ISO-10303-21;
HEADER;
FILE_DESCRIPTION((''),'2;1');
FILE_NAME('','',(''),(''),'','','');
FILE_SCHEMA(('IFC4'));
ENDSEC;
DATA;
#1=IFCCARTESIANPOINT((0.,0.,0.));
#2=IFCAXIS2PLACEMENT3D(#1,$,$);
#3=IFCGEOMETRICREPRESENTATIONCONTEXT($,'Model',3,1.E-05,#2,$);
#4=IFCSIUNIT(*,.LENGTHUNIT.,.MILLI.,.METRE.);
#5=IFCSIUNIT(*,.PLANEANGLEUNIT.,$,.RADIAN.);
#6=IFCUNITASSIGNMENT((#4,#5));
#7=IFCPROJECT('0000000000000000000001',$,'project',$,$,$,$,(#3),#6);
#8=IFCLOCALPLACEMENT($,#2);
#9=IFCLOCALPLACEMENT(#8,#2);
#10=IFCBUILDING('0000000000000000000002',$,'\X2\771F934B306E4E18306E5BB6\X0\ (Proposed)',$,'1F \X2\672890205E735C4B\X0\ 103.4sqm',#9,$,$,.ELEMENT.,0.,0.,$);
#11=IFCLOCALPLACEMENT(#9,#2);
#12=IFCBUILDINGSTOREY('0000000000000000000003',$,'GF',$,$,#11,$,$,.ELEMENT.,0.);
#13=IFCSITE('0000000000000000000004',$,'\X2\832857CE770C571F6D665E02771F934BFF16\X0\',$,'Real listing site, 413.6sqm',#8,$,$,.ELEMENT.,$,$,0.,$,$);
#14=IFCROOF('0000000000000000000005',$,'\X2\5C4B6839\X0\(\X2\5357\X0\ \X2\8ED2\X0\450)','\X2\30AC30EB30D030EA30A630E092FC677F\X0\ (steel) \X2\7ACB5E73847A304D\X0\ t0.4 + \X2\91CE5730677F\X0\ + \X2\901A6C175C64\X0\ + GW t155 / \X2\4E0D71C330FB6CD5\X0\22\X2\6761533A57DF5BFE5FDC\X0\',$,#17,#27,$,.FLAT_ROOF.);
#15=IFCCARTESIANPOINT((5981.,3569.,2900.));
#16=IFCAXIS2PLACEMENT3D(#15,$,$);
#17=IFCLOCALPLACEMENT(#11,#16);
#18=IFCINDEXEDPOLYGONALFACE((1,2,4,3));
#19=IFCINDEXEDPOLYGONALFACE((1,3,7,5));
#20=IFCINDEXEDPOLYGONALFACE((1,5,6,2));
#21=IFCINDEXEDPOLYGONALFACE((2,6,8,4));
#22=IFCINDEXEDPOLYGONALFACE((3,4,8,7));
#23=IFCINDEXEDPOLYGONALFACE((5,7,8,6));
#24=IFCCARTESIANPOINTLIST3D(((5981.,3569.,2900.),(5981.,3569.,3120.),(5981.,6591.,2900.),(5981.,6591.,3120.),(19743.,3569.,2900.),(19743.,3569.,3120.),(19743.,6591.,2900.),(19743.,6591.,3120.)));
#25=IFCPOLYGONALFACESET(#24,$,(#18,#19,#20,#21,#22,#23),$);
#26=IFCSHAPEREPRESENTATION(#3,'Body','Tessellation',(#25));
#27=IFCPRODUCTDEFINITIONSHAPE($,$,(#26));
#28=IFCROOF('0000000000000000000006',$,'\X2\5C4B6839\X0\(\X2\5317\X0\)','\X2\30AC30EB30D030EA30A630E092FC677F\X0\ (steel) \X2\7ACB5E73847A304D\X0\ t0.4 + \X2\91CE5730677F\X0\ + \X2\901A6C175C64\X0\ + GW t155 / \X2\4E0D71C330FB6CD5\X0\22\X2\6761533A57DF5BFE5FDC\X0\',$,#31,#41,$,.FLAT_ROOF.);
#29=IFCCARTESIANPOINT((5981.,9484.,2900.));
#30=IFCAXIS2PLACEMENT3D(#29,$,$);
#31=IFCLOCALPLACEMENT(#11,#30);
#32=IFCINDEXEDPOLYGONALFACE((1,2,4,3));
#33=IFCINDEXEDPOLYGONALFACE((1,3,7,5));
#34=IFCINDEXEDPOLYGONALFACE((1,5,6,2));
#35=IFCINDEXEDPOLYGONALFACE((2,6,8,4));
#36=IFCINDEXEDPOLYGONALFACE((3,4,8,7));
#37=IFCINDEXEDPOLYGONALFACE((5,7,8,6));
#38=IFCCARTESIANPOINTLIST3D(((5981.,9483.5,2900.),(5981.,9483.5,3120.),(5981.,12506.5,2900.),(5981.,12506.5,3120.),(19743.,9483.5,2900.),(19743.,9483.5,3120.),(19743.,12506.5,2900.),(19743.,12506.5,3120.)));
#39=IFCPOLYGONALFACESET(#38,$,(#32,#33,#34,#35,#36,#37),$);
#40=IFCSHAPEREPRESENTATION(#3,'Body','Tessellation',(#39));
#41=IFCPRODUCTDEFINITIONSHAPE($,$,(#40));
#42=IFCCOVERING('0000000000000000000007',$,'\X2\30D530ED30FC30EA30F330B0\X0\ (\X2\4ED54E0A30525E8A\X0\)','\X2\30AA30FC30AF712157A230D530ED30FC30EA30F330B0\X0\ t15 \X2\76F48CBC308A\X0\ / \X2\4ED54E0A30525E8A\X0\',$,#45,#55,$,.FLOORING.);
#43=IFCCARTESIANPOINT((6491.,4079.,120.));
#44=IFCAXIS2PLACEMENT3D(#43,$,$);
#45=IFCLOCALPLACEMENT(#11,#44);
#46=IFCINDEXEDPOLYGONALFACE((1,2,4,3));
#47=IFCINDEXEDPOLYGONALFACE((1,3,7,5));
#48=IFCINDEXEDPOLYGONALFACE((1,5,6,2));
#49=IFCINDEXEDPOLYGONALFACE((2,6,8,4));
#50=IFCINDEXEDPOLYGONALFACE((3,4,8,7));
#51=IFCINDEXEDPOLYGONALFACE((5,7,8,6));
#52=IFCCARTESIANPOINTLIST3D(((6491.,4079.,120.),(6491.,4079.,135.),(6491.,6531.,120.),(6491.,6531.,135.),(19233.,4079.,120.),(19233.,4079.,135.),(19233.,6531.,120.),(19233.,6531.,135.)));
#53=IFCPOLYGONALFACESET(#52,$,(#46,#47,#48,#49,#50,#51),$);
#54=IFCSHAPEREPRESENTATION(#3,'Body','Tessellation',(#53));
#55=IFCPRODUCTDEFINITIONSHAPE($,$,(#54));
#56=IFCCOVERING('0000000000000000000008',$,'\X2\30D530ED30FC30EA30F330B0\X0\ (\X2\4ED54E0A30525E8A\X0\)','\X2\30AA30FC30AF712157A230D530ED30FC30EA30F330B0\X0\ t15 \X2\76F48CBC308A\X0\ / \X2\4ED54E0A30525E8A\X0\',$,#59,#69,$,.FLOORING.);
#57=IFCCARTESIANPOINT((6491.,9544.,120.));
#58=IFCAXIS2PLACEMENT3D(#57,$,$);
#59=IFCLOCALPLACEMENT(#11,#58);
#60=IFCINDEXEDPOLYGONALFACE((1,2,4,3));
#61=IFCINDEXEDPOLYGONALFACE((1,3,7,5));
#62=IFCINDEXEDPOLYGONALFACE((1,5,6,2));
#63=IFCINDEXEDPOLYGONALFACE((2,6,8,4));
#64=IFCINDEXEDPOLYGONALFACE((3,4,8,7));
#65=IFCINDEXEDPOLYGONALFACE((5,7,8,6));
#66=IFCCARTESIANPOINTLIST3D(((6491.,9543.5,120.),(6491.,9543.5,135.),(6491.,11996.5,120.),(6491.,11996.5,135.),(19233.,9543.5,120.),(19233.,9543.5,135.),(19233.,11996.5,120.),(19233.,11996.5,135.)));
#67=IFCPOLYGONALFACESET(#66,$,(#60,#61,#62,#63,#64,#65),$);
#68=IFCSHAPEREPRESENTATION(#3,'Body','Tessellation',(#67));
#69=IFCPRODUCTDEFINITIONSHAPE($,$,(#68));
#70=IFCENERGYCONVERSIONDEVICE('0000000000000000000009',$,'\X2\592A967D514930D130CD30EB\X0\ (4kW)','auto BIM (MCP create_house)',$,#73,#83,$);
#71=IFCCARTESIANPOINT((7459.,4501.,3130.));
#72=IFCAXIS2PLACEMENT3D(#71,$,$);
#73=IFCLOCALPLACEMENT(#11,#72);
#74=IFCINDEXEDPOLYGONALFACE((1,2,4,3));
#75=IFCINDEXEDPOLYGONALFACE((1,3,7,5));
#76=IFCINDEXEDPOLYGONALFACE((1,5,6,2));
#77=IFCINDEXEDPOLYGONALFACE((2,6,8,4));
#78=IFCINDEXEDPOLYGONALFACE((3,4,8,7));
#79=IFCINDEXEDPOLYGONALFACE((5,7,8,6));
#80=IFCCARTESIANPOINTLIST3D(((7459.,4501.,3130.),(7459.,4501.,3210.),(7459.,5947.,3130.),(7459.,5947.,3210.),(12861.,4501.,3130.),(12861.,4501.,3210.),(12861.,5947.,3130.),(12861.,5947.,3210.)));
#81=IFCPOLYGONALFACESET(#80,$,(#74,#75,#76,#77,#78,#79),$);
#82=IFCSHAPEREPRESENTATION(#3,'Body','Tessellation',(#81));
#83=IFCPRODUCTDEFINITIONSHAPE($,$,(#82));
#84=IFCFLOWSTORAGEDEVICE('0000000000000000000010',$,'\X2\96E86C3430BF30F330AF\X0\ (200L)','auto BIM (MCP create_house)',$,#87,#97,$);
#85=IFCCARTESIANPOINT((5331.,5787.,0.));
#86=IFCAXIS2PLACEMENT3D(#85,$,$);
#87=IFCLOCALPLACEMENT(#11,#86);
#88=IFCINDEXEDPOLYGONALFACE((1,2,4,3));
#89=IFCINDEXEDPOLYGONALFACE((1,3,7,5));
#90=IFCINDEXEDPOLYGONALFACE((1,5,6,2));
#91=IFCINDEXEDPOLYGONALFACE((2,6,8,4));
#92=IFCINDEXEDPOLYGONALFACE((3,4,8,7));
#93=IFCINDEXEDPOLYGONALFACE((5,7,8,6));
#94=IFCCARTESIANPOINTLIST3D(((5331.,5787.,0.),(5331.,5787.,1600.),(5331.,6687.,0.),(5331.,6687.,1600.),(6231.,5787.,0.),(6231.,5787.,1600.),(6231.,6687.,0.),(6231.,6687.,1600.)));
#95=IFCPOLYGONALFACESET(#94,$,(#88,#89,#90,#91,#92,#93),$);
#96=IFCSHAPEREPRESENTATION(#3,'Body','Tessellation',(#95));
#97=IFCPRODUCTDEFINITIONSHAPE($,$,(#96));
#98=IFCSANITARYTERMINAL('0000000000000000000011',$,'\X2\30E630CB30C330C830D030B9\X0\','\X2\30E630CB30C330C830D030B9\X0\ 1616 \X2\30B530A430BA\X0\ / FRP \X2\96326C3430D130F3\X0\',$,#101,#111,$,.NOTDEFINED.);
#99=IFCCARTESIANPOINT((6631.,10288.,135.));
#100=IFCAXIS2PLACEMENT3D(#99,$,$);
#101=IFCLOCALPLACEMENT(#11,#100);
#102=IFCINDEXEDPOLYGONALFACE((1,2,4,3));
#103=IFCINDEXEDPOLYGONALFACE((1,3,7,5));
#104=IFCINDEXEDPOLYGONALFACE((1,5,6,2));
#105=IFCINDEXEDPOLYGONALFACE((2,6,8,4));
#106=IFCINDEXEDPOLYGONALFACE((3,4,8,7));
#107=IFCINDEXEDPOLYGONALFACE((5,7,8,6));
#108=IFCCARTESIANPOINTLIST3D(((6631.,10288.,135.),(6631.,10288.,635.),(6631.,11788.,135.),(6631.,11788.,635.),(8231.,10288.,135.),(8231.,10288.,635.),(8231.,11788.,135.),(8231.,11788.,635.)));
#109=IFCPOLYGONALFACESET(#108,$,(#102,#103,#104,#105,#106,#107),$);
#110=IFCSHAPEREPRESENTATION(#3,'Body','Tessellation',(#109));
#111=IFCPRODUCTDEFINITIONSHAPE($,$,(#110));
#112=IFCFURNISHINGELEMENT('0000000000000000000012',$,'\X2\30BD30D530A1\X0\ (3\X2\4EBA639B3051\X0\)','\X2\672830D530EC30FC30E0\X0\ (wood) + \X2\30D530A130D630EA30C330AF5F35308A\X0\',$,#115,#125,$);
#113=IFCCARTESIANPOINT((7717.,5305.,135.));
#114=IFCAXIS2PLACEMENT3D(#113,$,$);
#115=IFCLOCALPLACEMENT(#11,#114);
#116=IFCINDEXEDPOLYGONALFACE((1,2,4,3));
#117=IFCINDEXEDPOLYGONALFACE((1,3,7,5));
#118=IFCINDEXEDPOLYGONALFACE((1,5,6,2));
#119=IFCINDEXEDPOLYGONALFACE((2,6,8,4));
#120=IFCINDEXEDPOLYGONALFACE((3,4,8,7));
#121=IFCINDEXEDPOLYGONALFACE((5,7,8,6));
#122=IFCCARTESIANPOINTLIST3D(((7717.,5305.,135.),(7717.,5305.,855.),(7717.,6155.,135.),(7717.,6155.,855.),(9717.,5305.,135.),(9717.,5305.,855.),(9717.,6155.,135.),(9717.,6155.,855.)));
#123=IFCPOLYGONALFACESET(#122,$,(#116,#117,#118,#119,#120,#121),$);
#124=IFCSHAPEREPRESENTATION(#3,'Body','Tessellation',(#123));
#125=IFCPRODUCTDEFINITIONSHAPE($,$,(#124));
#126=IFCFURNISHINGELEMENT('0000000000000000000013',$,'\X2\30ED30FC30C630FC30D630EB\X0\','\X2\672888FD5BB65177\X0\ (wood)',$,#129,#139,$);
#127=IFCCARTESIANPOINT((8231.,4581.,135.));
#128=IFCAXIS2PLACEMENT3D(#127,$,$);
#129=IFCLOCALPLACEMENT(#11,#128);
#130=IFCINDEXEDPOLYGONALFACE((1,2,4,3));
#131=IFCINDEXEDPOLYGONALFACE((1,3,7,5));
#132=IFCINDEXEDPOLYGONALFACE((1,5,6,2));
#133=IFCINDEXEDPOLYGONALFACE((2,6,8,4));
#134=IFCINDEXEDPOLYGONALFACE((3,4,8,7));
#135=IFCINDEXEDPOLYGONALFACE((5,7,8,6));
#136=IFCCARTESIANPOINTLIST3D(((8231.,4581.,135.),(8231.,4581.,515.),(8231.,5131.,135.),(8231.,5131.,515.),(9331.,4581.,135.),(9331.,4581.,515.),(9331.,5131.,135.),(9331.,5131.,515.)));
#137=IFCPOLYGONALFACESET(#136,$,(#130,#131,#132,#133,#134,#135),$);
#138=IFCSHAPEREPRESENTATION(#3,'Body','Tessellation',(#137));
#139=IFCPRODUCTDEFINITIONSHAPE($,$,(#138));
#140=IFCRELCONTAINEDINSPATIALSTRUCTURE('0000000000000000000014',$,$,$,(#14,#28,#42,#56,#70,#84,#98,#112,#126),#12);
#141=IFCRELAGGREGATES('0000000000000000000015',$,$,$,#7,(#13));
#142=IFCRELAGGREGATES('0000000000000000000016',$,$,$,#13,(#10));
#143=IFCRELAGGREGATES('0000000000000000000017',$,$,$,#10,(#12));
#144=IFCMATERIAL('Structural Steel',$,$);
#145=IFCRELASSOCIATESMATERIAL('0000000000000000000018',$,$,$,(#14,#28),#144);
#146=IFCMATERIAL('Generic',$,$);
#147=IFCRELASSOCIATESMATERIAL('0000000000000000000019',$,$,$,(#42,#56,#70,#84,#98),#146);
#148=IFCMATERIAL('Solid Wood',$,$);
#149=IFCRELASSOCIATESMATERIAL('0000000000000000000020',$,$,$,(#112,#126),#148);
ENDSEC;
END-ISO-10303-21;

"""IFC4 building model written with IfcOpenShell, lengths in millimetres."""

from ifc_helpers import new_model, si_unit, frame, frame_2d, origin, place, context, project, spatial, rectangle, extrude, material, element, save


model = new_model("IFC4")

# Units and contexts
model_context = context("Model", 3, precision=1e-05, world=origin())
ifc_project = project(units=[si_unit("LENGTHUNIT", "METRE", prefix="MILLI"), si_unit("PLANEANGLEUNIT", "RADIAN")], contexts=[model_context])

# Site, building, storey
site_placement = place(None, origin())
site = spatial("IfcSite", under=ifc_project, at=site_placement, Name="茨城県土浦市真鍋６", ObjectType="Real listing site, 413.6sqm", CompositionType="ELEMENT", RefElevation=0.0)
building_placement = place(site_placement, origin())
building = spatial("IfcBuilding", under=site, at=building_placement, Name="真鍋の丘の家 (Proposed)", ObjectType="1F 木造平屋 103.4sqm", CompositionType="ELEMENT", ElevationOfRefHeight=0.0, ElevationOfTerrain=0.0)
storey_placement = place(building_placement, origin())
storey = spatial("IfcBuildingStorey", under=building, at=storey_placement, Name="GF", CompositionType="ELEMENT", Elevation=0.0)

# Shared definitions
ifc_material_1 = material(Name="Solid Wood")

# Roofs
ifc_material_2 = material(Name="Structural Steel")
roof_1_placement = place(storey_placement, frame((5981.0, 3569.0, 2900.0)))
element("IfcRoof", 1, at=roof_1_placement, inside=storey, material=ifc_material_2, Name="屋根(南 軒450)", Description="ガルバリウム鋼板 (steel) 立平葺き t0.4 + 野地板 + 通気層 + GW t155 / 不燃・法22条区域対応", PredefinedType="FLAT_ROOF", context=model_context, shape_type="SweptSolid", body=[
    extrude(rectangle(XDim=13762.0, YDim=3022.0, at=frame_2d((6881.0, 1511.0))), frame((5981.0, 3569.0, 2900.0)), (0.0, 0.0, 1.0), 220.0),
])
roof_2_placement = place(storey_placement, frame((5981.0, 9484.0, 2900.0)))
element("IfcRoof", 2, at=roof_2_placement, inside=storey, material=ifc_material_2, Name="屋根(北)", Description="ガルバリウム鋼板 (steel) 立平葺き t0.4 + 野地板 + 通気層 + GW t155 / 不燃・法22条区域対応", PredefinedType="FLAT_ROOF", context=model_context, shape_type="SweptSolid", body=[
    extrude(rectangle(XDim=13762.0, YDim=3023.0, at=frame_2d((6881.0, 1511.0))), frame((5981.0, 9484.0, 2900.0)), (0.0, 0.0, 1.0), 220.0),
])

# Coverings
ifc_material_3 = material(Name="Generic")
covering_1_placement = place(storey_placement, frame((6491.0, 4079.0, 120.0)))
element("IfcCovering", 3, at=covering_1_placement, inside=storey, material=ifc_material_3, Name="フローリング (仕上げ床)", Description="オーク無垢フローリング t15 直貼り / 仕上げ床", PredefinedType="FLOORING", context=model_context, shape_type="SweptSolid", body=[
    extrude(rectangle(XDim=12742.0, YDim=2452.0, at=frame_2d((6371.0, 1226.0))), frame((6491.0, 4079.0, 120.0)), (0.0, 0.0, 1.0), 15.0),
])
covering_2_placement = place(storey_placement, frame((6491.0, 9544.0, 120.0)))
element("IfcCovering", 4, at=covering_2_placement, inside=storey, material=ifc_material_3, Name="フローリング (仕上げ床)", Description="オーク無垢フローリング t15 直貼り / 仕上げ床", PredefinedType="FLOORING", context=model_context, shape_type="SweptSolid", body=[
    extrude(rectangle(XDim=12742.0, YDim=2453.0, at=frame_2d((6371.0, 1226.0))), frame((6491.0, 9544.0, 120.0)), (0.0, 0.0, 1.0), 15.0),
])

# Energy conversion device
energy_conversion_device_placement = place(storey_placement, frame((7459.0, 4501.0, 3130.0)))
element("IfcEnergyConversionDevice", 5, at=energy_conversion_device_placement, inside=storey, material=ifc_material_3, Name="太陽光パネル (4kW)", Description="auto BIM (MCP create_house)", context=model_context, shape_type="SweptSolid", body=[
    extrude(rectangle(XDim=5402.0, YDim=1446.0, at=frame_2d((2701.0, 723.0))), frame((7459.0, 4501.0, 3130.0)), (0.0, 0.0, 1.0), 80.0),
])

# Flow storage device
flow_storage_device_placement = place(storey_placement, frame((5331.0, 5787.0, 0.0)))
element("IfcFlowStorageDevice", 6, at=flow_storage_device_placement, inside=storey, material=ifc_material_3, Name="雨水タンク (200L)", Description="auto BIM (MCP create_house)", context=model_context, shape_type="SweptSolid", body=[
    extrude(rectangle(XDim=900.0, YDim=900.0, at=frame_2d((450.0, 450.0))), frame((5331.0, 5787.0, 0.0)), (0.0, 0.0, 1.0), 1600.0),
])

# Sanitary terminal
sanitary_terminal_placement = place(storey_placement, frame((6631.0, 10288.0, 135.0)))
element("IfcSanitaryTerminal", 7, at=sanitary_terminal_placement, inside=storey, material=ifc_material_3, Name="ユニットバス", Description="ユニットバス 1616 サイズ / FRP 防水パン", PredefinedType="NOTDEFINED", context=model_context, shape_type="SweptSolid", body=[
    extrude(rectangle(XDim=1600.0, YDim=1500.0, at=frame_2d((800.0, 750.0))), frame((6631.0, 10288.0, 135.0)), (0.0, 0.0, 1.0), 500.0),
])

# Furnishing elements
furnishing_1_placement = place(storey_placement, frame((7717.0, 5305.0, 135.0)))
element("IfcFurnishingElement", 8, at=furnishing_1_placement, inside=storey, material=ifc_material_1, Name="ソファ (3人掛け)", Description="木フレーム (wood) + ファブリック張り", context=model_context, shape_type="SweptSolid", body=[
    extrude(rectangle(XDim=2000.0, YDim=850.0, at=frame_2d((1000.0, 425.0))), frame((7717.0, 5305.0, 135.0)), (0.0, 0.0, 1.0), 720.0),
])
furnishing_2_placement = place(storey_placement, frame((8231.0, 4581.0, 135.0)))
element("IfcFurnishingElement", 9, at=furnishing_2_placement, inside=storey, material=ifc_material_1, Name="ローテーブル", Description="木製家具 (wood)", context=model_context, shape_type="SweptSolid", body=[
    extrude(rectangle(XDim=1100.0, YDim=550.0, at=frame_2d((550.0, 275.0))), frame((8231.0, 4581.0, 135.0)), (0.0, 0.0, 1.0), 380.0),
])

save(model, "model.ifc")
